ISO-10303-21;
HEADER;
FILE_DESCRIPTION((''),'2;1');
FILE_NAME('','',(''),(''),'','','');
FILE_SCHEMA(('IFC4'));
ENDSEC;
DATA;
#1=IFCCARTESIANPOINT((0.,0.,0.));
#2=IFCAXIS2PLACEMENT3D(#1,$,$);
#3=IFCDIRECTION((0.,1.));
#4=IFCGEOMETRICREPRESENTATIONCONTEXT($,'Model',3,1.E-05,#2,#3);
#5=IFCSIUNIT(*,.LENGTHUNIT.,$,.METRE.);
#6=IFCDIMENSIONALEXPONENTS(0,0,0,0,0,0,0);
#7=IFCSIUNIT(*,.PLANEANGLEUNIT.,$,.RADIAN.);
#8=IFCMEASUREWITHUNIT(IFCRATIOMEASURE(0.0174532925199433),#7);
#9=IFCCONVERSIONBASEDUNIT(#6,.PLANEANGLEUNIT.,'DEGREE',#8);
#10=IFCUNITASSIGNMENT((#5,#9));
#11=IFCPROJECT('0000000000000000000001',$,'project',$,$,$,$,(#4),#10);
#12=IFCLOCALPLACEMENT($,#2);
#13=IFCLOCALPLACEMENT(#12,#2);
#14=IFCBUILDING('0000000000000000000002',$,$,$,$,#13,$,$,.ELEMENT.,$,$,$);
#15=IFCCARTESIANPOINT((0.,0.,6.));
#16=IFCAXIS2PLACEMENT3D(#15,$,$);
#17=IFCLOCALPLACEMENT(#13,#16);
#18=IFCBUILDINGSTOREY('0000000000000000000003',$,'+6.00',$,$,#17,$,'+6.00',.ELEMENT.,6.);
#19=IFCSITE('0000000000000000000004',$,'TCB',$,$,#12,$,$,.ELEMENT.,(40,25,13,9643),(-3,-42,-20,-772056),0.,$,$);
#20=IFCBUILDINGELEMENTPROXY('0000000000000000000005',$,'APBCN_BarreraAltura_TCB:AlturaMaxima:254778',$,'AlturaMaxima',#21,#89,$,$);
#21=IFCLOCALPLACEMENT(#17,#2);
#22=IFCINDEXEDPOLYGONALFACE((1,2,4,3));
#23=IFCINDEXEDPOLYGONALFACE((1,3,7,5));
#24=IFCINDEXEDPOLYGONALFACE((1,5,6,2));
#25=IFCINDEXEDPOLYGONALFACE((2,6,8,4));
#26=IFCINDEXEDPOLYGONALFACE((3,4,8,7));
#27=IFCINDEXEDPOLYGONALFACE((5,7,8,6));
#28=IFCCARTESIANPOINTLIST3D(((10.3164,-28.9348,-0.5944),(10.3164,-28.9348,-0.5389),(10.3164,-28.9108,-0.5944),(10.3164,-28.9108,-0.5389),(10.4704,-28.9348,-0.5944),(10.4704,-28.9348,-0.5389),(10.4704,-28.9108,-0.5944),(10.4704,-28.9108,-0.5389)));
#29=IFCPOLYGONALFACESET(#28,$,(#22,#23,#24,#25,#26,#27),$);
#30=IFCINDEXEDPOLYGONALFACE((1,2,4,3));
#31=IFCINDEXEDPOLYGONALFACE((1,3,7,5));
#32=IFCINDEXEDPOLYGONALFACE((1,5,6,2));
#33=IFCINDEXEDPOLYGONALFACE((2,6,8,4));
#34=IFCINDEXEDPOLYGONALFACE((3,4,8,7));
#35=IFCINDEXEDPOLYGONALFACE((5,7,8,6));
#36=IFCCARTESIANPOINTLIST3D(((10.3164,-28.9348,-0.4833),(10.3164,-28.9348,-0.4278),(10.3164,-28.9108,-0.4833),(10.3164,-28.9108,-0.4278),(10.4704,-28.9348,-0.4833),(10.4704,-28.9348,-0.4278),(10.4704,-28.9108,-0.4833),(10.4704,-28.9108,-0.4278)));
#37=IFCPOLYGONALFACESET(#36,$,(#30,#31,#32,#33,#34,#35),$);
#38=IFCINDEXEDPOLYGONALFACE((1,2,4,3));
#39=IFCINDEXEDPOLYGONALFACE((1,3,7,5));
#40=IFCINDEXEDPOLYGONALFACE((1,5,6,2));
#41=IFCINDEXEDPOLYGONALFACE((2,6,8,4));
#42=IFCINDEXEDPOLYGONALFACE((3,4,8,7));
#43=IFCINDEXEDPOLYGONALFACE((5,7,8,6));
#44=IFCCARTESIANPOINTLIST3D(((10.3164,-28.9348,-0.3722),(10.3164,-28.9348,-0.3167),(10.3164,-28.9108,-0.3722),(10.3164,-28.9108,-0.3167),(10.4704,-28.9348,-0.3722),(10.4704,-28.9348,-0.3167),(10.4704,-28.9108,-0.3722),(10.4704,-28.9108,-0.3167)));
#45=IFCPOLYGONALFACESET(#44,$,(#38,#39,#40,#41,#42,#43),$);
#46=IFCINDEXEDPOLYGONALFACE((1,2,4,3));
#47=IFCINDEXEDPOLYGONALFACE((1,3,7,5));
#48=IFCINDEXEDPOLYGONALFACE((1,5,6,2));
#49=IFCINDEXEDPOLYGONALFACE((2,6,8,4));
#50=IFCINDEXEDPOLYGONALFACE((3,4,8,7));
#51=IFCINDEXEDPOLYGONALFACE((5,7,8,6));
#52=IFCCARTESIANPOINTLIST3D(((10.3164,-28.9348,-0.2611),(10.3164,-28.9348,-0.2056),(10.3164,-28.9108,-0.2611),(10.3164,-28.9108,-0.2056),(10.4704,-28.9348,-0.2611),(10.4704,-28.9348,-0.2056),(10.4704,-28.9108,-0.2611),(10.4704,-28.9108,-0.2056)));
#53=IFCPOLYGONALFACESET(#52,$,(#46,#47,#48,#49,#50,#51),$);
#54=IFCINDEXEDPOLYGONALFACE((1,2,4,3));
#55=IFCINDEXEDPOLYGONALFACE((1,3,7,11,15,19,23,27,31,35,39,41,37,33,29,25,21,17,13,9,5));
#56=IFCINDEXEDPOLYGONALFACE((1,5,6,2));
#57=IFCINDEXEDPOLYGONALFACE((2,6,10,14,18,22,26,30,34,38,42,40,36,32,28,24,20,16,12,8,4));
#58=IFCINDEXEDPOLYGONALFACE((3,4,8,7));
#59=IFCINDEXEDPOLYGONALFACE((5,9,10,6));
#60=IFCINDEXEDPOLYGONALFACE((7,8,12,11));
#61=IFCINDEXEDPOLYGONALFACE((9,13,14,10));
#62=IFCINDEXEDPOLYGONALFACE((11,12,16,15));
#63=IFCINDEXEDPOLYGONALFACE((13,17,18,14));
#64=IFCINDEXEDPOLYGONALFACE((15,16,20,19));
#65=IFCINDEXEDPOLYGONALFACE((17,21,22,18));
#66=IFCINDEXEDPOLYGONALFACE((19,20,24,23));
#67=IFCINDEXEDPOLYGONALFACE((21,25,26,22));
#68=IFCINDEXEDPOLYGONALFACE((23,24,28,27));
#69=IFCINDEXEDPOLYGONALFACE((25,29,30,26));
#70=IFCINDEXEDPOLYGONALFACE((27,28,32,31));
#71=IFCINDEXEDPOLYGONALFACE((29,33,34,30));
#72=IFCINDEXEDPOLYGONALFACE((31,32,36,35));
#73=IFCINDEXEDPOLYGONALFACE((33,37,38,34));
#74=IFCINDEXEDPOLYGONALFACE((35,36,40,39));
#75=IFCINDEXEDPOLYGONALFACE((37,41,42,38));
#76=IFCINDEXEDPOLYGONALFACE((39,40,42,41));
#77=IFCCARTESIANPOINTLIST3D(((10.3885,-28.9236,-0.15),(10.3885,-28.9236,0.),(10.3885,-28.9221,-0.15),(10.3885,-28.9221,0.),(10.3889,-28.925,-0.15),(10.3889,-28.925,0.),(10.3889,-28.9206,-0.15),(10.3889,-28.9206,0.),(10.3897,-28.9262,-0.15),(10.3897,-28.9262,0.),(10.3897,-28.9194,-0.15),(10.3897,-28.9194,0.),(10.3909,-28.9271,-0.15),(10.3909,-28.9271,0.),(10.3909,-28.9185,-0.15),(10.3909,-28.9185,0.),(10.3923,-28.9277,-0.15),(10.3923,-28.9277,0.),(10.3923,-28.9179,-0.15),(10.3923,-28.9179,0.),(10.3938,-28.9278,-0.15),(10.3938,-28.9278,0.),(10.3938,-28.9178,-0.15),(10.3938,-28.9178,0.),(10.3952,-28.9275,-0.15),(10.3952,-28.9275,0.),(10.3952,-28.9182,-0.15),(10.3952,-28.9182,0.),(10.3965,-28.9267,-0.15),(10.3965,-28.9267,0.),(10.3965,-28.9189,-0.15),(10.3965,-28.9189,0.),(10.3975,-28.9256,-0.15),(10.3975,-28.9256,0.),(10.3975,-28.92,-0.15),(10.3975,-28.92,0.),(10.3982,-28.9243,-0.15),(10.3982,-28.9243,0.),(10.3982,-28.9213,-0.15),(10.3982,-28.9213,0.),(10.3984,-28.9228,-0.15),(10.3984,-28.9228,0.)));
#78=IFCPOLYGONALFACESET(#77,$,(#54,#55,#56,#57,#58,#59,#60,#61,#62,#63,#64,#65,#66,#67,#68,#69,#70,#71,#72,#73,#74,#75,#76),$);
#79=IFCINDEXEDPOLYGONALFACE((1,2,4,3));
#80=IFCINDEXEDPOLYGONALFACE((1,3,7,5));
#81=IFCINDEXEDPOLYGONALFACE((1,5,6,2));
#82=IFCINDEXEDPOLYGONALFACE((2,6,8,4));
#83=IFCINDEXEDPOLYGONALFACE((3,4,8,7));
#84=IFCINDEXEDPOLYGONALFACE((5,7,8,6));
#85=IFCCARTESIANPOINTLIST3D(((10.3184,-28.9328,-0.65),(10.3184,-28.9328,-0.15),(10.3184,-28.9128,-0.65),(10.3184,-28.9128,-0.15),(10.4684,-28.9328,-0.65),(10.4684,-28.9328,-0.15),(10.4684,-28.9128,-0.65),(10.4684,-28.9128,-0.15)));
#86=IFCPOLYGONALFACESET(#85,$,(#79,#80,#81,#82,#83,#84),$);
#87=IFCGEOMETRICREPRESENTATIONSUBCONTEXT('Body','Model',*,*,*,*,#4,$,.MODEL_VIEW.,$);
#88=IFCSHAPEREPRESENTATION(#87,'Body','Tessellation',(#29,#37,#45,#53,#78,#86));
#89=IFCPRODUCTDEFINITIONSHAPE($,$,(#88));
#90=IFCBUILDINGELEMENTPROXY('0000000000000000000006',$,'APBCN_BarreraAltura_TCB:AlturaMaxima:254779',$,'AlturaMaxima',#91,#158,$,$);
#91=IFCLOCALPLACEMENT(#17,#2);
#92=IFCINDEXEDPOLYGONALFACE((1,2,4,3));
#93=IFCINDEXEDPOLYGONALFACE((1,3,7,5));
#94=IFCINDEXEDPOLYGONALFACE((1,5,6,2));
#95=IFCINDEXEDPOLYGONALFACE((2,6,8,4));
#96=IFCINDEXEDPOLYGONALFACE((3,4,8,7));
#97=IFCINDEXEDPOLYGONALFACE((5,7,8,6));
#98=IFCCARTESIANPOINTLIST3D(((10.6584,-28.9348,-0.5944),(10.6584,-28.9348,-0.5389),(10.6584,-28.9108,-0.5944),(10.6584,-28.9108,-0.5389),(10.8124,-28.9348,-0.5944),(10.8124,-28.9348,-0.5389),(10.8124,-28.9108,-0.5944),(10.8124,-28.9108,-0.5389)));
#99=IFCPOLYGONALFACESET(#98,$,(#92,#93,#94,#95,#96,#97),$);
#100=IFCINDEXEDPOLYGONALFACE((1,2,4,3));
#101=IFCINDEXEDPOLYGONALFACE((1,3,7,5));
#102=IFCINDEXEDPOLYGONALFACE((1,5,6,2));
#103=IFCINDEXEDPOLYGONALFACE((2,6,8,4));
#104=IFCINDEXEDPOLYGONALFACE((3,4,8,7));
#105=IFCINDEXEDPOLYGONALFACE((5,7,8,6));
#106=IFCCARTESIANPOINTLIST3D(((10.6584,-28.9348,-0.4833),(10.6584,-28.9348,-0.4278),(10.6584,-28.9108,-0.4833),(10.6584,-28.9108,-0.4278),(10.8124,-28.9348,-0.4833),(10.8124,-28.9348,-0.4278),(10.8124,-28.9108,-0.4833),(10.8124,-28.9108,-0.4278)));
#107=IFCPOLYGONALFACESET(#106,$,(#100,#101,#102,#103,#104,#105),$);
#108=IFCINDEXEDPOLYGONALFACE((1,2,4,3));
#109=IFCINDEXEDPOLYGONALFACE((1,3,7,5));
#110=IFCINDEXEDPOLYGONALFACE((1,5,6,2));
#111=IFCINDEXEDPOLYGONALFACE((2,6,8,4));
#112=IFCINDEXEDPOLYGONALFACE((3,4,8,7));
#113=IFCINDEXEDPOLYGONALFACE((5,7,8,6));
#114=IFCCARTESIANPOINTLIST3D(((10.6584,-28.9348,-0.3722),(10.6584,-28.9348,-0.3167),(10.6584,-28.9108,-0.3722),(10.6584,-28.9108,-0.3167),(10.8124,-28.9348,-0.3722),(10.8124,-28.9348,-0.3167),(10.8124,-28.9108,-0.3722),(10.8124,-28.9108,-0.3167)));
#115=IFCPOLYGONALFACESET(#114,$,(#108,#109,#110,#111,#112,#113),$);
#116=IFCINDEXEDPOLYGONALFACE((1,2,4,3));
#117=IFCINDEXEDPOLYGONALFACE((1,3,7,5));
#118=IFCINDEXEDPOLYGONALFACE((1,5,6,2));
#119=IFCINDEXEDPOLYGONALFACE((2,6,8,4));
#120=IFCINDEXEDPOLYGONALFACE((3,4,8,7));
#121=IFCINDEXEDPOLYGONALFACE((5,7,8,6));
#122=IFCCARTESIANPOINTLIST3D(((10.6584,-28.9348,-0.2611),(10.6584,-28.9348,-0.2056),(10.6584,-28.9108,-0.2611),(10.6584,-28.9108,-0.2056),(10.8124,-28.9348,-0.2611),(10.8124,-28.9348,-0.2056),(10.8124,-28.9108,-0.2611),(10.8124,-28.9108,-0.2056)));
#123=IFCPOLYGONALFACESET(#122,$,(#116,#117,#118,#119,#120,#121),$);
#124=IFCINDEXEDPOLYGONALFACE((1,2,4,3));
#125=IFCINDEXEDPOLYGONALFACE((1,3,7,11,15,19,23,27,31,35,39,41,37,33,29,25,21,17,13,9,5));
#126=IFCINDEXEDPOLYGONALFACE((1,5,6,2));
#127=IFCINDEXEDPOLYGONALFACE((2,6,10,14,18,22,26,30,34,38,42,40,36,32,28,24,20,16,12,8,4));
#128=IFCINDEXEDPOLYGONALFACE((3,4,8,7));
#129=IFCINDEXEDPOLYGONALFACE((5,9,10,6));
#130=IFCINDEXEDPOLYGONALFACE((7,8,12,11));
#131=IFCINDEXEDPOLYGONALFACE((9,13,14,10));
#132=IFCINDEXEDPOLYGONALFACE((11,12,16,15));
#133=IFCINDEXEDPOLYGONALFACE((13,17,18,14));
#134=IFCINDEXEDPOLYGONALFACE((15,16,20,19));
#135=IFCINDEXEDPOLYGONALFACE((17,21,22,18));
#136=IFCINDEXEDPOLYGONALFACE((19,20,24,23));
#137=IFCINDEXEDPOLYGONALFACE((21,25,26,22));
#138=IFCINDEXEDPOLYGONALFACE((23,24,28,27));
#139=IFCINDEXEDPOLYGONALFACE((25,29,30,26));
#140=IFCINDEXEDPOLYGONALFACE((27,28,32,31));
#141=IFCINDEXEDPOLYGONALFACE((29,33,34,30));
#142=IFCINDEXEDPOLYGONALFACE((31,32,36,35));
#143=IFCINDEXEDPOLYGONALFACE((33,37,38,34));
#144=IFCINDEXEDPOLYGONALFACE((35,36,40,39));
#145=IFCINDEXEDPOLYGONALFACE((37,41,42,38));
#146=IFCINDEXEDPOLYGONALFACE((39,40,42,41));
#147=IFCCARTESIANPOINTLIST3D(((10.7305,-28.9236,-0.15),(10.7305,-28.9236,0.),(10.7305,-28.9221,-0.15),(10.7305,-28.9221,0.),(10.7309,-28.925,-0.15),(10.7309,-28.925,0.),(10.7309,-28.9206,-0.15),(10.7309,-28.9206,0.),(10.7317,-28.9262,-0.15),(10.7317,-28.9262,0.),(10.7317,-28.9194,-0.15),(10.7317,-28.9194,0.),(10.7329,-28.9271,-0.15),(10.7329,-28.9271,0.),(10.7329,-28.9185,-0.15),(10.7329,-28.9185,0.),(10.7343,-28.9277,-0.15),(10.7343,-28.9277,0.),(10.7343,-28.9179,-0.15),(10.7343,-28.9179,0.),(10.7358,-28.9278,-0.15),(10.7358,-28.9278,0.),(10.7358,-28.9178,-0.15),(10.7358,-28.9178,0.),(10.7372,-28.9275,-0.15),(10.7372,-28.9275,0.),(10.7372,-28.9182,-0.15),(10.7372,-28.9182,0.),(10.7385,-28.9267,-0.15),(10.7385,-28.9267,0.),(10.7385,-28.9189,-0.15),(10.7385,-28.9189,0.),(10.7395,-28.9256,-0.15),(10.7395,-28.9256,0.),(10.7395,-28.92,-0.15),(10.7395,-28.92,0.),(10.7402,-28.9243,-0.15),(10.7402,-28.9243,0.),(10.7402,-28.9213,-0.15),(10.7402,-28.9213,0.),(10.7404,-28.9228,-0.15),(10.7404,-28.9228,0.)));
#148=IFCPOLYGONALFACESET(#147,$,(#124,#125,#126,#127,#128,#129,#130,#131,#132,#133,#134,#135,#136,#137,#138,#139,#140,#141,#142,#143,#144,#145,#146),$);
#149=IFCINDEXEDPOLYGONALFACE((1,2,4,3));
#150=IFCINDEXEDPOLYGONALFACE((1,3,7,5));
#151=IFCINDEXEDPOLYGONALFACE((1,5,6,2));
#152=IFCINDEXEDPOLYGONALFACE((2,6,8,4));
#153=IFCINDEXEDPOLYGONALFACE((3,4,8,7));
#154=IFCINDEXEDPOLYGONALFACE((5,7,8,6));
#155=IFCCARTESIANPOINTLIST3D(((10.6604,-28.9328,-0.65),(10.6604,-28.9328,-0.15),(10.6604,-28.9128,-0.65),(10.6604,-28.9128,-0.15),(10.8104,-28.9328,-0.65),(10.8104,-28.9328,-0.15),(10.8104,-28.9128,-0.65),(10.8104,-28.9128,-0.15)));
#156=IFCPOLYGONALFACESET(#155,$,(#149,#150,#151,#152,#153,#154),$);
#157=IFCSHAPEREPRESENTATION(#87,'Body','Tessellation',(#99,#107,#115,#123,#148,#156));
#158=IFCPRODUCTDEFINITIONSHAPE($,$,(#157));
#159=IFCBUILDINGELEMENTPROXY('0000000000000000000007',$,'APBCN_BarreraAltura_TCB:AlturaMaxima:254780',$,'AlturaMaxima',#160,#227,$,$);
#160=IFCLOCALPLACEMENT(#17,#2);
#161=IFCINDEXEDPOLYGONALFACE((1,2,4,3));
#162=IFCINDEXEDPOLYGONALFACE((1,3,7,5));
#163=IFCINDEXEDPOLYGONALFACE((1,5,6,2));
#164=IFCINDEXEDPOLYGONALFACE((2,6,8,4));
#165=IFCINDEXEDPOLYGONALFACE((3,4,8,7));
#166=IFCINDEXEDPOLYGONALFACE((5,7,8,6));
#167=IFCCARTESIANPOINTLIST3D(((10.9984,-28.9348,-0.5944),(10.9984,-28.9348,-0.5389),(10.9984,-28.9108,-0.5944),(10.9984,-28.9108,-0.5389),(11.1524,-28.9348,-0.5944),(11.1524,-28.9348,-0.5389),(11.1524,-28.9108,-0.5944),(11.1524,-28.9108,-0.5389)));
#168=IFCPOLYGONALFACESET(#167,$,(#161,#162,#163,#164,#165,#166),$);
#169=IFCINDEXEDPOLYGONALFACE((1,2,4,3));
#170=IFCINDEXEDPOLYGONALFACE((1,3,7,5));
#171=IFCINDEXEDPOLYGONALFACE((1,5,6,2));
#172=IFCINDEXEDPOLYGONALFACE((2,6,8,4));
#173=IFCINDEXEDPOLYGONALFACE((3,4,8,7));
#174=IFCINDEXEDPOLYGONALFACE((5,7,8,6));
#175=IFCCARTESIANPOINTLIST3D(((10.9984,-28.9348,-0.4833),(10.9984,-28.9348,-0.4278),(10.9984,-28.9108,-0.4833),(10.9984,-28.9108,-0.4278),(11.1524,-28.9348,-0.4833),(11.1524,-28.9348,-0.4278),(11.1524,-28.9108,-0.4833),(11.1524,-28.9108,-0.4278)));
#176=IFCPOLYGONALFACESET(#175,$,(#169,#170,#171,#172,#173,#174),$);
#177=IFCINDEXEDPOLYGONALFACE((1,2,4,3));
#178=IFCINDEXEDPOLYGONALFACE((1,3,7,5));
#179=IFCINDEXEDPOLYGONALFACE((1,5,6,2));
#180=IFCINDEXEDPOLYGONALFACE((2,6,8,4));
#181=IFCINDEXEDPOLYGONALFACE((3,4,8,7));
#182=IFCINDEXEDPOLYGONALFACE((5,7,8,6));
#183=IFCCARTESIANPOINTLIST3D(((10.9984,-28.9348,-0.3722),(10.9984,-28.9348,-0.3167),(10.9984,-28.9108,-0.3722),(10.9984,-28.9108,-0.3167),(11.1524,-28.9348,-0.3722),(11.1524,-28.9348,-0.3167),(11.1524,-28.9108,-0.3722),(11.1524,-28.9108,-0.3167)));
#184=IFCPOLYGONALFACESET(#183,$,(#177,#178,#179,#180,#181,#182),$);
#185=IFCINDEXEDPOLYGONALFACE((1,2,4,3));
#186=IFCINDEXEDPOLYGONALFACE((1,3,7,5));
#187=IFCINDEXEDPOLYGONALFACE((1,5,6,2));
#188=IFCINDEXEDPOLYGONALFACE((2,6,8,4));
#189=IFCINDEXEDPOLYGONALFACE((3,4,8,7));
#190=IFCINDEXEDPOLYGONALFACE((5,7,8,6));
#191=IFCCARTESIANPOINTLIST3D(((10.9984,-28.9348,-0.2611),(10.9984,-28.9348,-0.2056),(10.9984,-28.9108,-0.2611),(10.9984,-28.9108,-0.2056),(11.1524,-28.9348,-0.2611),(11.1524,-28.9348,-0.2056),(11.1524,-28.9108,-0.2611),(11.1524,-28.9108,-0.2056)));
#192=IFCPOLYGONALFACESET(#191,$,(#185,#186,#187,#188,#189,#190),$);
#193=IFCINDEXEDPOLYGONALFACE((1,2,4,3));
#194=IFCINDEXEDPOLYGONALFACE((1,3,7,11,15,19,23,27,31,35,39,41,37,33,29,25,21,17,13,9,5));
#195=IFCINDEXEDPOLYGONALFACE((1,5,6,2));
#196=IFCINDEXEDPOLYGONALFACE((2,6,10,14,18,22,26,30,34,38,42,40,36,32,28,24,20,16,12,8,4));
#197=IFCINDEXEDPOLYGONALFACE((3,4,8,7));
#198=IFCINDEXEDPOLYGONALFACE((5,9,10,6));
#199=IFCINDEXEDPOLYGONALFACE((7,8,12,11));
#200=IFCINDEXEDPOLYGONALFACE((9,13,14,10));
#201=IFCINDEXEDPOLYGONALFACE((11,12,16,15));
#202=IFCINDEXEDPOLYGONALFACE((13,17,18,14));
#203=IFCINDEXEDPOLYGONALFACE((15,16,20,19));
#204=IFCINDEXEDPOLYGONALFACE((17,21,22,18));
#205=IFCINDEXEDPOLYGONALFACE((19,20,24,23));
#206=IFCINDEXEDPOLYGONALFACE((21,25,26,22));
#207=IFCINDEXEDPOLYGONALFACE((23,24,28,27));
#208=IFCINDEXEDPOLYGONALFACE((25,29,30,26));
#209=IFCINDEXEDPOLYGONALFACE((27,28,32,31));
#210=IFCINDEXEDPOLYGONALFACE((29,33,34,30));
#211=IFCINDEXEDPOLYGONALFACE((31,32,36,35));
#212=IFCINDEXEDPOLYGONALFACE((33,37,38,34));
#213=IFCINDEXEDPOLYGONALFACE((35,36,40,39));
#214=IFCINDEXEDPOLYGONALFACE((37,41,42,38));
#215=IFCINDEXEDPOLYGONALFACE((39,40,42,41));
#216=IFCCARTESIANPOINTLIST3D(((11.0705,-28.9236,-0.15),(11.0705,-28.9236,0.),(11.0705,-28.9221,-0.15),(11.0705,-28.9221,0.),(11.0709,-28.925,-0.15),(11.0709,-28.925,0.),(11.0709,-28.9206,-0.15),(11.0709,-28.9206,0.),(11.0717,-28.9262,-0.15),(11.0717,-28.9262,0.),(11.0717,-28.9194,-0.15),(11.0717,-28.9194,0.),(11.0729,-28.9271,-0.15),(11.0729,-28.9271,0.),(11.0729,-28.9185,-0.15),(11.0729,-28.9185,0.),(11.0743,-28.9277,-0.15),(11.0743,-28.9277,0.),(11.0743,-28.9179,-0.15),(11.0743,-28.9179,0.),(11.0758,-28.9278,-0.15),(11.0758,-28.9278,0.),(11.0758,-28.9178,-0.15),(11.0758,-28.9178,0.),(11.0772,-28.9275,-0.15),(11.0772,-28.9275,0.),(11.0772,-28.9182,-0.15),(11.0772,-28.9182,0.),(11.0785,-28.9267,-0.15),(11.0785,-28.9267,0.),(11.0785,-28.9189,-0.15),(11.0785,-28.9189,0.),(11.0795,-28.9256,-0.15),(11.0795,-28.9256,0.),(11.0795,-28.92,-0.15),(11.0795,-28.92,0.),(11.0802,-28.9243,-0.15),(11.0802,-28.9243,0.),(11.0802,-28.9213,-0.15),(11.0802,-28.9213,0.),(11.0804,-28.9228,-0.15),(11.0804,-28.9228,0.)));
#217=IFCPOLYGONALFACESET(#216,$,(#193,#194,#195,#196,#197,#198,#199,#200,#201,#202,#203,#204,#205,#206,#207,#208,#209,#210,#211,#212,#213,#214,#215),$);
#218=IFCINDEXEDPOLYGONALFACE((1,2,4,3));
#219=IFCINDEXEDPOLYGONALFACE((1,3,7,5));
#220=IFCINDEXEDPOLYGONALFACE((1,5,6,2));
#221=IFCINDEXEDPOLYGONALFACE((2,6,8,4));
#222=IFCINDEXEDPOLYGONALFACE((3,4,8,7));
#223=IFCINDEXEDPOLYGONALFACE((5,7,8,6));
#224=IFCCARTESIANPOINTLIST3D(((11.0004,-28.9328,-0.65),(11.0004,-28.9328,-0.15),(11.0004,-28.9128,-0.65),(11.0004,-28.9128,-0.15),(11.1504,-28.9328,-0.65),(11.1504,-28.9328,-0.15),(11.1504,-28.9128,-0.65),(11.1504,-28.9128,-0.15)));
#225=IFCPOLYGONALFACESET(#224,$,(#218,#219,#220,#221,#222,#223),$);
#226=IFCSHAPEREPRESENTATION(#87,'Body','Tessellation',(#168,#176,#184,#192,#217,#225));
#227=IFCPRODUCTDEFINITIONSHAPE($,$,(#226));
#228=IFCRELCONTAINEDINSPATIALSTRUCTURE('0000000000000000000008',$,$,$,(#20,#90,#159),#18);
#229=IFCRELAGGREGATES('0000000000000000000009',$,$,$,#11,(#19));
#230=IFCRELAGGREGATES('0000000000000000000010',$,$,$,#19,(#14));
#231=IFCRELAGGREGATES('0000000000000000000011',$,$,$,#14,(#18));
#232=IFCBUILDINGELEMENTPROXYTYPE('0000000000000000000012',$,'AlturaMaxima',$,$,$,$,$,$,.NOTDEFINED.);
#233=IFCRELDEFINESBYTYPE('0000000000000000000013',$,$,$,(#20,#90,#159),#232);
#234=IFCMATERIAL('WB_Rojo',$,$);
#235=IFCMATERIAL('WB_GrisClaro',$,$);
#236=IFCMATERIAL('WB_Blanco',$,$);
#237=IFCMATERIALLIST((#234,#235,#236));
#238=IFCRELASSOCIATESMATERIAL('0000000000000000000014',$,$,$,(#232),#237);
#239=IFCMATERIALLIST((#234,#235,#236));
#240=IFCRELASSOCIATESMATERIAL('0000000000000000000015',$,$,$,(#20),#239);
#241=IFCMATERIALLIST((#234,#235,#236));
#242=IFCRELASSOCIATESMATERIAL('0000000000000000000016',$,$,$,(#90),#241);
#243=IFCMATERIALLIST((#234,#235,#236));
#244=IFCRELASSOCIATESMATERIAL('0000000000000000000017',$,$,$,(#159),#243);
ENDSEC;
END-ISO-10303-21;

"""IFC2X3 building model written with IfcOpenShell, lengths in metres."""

from ifc_helpers import new_model, entity, si_unit, converted_unit, direction, frame, frame_2d, origin, origin_2d_with_axis, place, context, subcontext, project, spatial, rectangle, circle, extrude, source, transform, mapped, material, material_list, type_object, type_shapes, element, save


model = new_model("IFC2X3")

# Units and contexts
model_context = context("Model", 3, precision=1e-05, world=origin(), true_north=direction((0.0, 1.0)))
body_context = subcontext(model_context, "Body", "Model", "MODEL_VIEW")
ifc_project = project(units=[si_unit("LENGTHUNIT", "METRE"), converted_unit("PLANEANGLEUNIT", "DEGREE", entity("IfcRatioMeasure", 0.0174532925199433), si_unit("PLANEANGLEUNIT", "RADIAN"), dimensions=[0, 0, 0, 0, 0, 0, 0])], contexts=[model_context])

# Site, building, storey
site_placement = place(None, origin())
site = spatial("IfcSite", under=ifc_project, at=site_placement, Name="TCB", CompositionType="ELEMENT", RefLatitude=(40, 25, 13, 9643), RefLongitude=(-3, -42, -20, -772056), RefElevation=0.0)
building_placement = place(site_placement, origin())
building = spatial("IfcBuilding", under=site, at=building_placement, CompositionType="ELEMENT")
storey_placement = place(building_placement, frame((0.0, 0.0, 6.0)))
storey = spatial("IfcBuildingStorey", under=building, at=storey_placement, Name="+6.00", LongName="+6.00", CompositionType="ELEMENT", Elevation=6.0)

# Building element proxies
ifc_material_1 = material(Name="WB_Rojo")
ifc_material_2 = material(Name="WB_GrisClaro")
ifc_material_3 = material(Name="WB_Blanco")
ifc_material_list_1 = material_list([ifc_material_1, ifc_material_2, ifc_material_3])
building_element_proxy_type = type_object("IfcBuildingElementProxyType", Name="AlturaMaxima", PredefinedType="NOTDEFINED", material=ifc_material_list_1)
shared_shape = source(origin(), body_context, "Body", "SweptSolid", [
    extrude(rectangle(XDim=0.154, YDim=0.024, at=frame_2d((0.0, 0.0), x_axis=(1.0, 0.0))), frame((0.0, 0.0, -0.5944), z_axis=(0.0, 0.0, 1.0), x_axis=(-1.0, 0.0, 0.0)), (0.0, 0.0, 1.0), 0.0556),
    extrude(rectangle(XDim=0.154, YDim=0.024, at=frame_2d((0.0, 0.0), x_axis=(1.0, 0.0))), frame((0.0, 0.0, -0.4833), z_axis=(0.0, 0.0, 1.0), x_axis=(-1.0, 0.0, 0.0)), (0.0, 0.0, 1.0), 0.0556),
    extrude(rectangle(XDim=0.154, YDim=0.024, at=frame_2d((0.0, 0.0), x_axis=(1.0, 0.0))), frame((0.0, 0.0, -0.3722), z_axis=(0.0, 0.0, 1.0), x_axis=(-1.0, 0.0, 0.0)), (0.0, 0.0, 1.0), 0.0556),
    extrude(rectangle(XDim=0.154, YDim=0.024, at=frame_2d((0.0, 0.0), x_axis=(1.0, 0.0))), frame((0.0, 0.0, -0.2611), z_axis=(0.0, 0.0, 1.0), x_axis=(-1.0, 0.0, 0.0)), (0.0, 0.0, 1.0), 0.0556),
    extrude(circle(Radius=0.005, at=frame_2d((0.0, 0.0), x_axis=(1.0, 0.0))), frame((0.0, 0.0, -0.15)), (0.0, 0.0, 1.0), 0.15),
    extrude(rectangle(XDim=0.02, YDim=0.15, at=origin_2d_with_axis()), frame((0.0, 0.0, -0.65), z_axis=(0.0, 0.0, 1.0), x_axis=(0.0, 1.0, 0.0)), (0.0, 0.0, 1.0), 0.5),
])
type_shapes(building_element_proxy_type, [shared_shape])
ifc_material_list_2 = material_list([ifc_material_1, ifc_material_2, ifc_material_3])
proxy_1_placement = place(storey_placement, frame((10.3934, -28.9228, 0.0)))
element("IfcBuildingElementProxy", 1, at=proxy_1_placement, inside=storey, type_object=building_element_proxy_type, material=ifc_material_list_2, Name="APBCN_BarreraAltura_TCB:AlturaMaxima:254778", ObjectType="AlturaMaxima", context=body_context, shape_type="MappedRepresentation", body=[
    mapped(shared_shape, transform((0.0, 0.0, 0.0), scale=1.0)),
])
ifc_material_list_3 = material_list([ifc_material_1, ifc_material_2, ifc_material_3])
proxy_2_placement = place(storey_placement, frame((10.7354, -28.9228, 0.0)))
element("IfcBuildingElementProxy", 2, at=proxy_2_placement, inside=storey, type_object=building_element_proxy_type, material=ifc_material_list_3, Name="APBCN_BarreraAltura_TCB:AlturaMaxima:254779", ObjectType="AlturaMaxima", context=body_context, shape_type="MappedRepresentation", body=[
    mapped(shared_shape, transform((0.0, 0.0, 0.0), scale=1.0)),
])
ifc_material_list_4 = material_list([ifc_material_1, ifc_material_2, ifc_material_3])
proxy_3_placement = place(storey_placement, frame((11.0754, -28.9228, 0.0)))
element("IfcBuildingElementProxy", 3, at=proxy_3_placement, inside=storey, type_object=building_element_proxy_type, material=ifc_material_list_4, Name="APBCN_BarreraAltura_TCB:AlturaMaxima:254780", ObjectType="AlturaMaxima", context=body_context, shape_type="MappedRepresentation", body=[
    mapped(shared_shape, transform((0.0, 0.0, 0.0), scale=1.0)),
])

save(model, "model.ifc")
